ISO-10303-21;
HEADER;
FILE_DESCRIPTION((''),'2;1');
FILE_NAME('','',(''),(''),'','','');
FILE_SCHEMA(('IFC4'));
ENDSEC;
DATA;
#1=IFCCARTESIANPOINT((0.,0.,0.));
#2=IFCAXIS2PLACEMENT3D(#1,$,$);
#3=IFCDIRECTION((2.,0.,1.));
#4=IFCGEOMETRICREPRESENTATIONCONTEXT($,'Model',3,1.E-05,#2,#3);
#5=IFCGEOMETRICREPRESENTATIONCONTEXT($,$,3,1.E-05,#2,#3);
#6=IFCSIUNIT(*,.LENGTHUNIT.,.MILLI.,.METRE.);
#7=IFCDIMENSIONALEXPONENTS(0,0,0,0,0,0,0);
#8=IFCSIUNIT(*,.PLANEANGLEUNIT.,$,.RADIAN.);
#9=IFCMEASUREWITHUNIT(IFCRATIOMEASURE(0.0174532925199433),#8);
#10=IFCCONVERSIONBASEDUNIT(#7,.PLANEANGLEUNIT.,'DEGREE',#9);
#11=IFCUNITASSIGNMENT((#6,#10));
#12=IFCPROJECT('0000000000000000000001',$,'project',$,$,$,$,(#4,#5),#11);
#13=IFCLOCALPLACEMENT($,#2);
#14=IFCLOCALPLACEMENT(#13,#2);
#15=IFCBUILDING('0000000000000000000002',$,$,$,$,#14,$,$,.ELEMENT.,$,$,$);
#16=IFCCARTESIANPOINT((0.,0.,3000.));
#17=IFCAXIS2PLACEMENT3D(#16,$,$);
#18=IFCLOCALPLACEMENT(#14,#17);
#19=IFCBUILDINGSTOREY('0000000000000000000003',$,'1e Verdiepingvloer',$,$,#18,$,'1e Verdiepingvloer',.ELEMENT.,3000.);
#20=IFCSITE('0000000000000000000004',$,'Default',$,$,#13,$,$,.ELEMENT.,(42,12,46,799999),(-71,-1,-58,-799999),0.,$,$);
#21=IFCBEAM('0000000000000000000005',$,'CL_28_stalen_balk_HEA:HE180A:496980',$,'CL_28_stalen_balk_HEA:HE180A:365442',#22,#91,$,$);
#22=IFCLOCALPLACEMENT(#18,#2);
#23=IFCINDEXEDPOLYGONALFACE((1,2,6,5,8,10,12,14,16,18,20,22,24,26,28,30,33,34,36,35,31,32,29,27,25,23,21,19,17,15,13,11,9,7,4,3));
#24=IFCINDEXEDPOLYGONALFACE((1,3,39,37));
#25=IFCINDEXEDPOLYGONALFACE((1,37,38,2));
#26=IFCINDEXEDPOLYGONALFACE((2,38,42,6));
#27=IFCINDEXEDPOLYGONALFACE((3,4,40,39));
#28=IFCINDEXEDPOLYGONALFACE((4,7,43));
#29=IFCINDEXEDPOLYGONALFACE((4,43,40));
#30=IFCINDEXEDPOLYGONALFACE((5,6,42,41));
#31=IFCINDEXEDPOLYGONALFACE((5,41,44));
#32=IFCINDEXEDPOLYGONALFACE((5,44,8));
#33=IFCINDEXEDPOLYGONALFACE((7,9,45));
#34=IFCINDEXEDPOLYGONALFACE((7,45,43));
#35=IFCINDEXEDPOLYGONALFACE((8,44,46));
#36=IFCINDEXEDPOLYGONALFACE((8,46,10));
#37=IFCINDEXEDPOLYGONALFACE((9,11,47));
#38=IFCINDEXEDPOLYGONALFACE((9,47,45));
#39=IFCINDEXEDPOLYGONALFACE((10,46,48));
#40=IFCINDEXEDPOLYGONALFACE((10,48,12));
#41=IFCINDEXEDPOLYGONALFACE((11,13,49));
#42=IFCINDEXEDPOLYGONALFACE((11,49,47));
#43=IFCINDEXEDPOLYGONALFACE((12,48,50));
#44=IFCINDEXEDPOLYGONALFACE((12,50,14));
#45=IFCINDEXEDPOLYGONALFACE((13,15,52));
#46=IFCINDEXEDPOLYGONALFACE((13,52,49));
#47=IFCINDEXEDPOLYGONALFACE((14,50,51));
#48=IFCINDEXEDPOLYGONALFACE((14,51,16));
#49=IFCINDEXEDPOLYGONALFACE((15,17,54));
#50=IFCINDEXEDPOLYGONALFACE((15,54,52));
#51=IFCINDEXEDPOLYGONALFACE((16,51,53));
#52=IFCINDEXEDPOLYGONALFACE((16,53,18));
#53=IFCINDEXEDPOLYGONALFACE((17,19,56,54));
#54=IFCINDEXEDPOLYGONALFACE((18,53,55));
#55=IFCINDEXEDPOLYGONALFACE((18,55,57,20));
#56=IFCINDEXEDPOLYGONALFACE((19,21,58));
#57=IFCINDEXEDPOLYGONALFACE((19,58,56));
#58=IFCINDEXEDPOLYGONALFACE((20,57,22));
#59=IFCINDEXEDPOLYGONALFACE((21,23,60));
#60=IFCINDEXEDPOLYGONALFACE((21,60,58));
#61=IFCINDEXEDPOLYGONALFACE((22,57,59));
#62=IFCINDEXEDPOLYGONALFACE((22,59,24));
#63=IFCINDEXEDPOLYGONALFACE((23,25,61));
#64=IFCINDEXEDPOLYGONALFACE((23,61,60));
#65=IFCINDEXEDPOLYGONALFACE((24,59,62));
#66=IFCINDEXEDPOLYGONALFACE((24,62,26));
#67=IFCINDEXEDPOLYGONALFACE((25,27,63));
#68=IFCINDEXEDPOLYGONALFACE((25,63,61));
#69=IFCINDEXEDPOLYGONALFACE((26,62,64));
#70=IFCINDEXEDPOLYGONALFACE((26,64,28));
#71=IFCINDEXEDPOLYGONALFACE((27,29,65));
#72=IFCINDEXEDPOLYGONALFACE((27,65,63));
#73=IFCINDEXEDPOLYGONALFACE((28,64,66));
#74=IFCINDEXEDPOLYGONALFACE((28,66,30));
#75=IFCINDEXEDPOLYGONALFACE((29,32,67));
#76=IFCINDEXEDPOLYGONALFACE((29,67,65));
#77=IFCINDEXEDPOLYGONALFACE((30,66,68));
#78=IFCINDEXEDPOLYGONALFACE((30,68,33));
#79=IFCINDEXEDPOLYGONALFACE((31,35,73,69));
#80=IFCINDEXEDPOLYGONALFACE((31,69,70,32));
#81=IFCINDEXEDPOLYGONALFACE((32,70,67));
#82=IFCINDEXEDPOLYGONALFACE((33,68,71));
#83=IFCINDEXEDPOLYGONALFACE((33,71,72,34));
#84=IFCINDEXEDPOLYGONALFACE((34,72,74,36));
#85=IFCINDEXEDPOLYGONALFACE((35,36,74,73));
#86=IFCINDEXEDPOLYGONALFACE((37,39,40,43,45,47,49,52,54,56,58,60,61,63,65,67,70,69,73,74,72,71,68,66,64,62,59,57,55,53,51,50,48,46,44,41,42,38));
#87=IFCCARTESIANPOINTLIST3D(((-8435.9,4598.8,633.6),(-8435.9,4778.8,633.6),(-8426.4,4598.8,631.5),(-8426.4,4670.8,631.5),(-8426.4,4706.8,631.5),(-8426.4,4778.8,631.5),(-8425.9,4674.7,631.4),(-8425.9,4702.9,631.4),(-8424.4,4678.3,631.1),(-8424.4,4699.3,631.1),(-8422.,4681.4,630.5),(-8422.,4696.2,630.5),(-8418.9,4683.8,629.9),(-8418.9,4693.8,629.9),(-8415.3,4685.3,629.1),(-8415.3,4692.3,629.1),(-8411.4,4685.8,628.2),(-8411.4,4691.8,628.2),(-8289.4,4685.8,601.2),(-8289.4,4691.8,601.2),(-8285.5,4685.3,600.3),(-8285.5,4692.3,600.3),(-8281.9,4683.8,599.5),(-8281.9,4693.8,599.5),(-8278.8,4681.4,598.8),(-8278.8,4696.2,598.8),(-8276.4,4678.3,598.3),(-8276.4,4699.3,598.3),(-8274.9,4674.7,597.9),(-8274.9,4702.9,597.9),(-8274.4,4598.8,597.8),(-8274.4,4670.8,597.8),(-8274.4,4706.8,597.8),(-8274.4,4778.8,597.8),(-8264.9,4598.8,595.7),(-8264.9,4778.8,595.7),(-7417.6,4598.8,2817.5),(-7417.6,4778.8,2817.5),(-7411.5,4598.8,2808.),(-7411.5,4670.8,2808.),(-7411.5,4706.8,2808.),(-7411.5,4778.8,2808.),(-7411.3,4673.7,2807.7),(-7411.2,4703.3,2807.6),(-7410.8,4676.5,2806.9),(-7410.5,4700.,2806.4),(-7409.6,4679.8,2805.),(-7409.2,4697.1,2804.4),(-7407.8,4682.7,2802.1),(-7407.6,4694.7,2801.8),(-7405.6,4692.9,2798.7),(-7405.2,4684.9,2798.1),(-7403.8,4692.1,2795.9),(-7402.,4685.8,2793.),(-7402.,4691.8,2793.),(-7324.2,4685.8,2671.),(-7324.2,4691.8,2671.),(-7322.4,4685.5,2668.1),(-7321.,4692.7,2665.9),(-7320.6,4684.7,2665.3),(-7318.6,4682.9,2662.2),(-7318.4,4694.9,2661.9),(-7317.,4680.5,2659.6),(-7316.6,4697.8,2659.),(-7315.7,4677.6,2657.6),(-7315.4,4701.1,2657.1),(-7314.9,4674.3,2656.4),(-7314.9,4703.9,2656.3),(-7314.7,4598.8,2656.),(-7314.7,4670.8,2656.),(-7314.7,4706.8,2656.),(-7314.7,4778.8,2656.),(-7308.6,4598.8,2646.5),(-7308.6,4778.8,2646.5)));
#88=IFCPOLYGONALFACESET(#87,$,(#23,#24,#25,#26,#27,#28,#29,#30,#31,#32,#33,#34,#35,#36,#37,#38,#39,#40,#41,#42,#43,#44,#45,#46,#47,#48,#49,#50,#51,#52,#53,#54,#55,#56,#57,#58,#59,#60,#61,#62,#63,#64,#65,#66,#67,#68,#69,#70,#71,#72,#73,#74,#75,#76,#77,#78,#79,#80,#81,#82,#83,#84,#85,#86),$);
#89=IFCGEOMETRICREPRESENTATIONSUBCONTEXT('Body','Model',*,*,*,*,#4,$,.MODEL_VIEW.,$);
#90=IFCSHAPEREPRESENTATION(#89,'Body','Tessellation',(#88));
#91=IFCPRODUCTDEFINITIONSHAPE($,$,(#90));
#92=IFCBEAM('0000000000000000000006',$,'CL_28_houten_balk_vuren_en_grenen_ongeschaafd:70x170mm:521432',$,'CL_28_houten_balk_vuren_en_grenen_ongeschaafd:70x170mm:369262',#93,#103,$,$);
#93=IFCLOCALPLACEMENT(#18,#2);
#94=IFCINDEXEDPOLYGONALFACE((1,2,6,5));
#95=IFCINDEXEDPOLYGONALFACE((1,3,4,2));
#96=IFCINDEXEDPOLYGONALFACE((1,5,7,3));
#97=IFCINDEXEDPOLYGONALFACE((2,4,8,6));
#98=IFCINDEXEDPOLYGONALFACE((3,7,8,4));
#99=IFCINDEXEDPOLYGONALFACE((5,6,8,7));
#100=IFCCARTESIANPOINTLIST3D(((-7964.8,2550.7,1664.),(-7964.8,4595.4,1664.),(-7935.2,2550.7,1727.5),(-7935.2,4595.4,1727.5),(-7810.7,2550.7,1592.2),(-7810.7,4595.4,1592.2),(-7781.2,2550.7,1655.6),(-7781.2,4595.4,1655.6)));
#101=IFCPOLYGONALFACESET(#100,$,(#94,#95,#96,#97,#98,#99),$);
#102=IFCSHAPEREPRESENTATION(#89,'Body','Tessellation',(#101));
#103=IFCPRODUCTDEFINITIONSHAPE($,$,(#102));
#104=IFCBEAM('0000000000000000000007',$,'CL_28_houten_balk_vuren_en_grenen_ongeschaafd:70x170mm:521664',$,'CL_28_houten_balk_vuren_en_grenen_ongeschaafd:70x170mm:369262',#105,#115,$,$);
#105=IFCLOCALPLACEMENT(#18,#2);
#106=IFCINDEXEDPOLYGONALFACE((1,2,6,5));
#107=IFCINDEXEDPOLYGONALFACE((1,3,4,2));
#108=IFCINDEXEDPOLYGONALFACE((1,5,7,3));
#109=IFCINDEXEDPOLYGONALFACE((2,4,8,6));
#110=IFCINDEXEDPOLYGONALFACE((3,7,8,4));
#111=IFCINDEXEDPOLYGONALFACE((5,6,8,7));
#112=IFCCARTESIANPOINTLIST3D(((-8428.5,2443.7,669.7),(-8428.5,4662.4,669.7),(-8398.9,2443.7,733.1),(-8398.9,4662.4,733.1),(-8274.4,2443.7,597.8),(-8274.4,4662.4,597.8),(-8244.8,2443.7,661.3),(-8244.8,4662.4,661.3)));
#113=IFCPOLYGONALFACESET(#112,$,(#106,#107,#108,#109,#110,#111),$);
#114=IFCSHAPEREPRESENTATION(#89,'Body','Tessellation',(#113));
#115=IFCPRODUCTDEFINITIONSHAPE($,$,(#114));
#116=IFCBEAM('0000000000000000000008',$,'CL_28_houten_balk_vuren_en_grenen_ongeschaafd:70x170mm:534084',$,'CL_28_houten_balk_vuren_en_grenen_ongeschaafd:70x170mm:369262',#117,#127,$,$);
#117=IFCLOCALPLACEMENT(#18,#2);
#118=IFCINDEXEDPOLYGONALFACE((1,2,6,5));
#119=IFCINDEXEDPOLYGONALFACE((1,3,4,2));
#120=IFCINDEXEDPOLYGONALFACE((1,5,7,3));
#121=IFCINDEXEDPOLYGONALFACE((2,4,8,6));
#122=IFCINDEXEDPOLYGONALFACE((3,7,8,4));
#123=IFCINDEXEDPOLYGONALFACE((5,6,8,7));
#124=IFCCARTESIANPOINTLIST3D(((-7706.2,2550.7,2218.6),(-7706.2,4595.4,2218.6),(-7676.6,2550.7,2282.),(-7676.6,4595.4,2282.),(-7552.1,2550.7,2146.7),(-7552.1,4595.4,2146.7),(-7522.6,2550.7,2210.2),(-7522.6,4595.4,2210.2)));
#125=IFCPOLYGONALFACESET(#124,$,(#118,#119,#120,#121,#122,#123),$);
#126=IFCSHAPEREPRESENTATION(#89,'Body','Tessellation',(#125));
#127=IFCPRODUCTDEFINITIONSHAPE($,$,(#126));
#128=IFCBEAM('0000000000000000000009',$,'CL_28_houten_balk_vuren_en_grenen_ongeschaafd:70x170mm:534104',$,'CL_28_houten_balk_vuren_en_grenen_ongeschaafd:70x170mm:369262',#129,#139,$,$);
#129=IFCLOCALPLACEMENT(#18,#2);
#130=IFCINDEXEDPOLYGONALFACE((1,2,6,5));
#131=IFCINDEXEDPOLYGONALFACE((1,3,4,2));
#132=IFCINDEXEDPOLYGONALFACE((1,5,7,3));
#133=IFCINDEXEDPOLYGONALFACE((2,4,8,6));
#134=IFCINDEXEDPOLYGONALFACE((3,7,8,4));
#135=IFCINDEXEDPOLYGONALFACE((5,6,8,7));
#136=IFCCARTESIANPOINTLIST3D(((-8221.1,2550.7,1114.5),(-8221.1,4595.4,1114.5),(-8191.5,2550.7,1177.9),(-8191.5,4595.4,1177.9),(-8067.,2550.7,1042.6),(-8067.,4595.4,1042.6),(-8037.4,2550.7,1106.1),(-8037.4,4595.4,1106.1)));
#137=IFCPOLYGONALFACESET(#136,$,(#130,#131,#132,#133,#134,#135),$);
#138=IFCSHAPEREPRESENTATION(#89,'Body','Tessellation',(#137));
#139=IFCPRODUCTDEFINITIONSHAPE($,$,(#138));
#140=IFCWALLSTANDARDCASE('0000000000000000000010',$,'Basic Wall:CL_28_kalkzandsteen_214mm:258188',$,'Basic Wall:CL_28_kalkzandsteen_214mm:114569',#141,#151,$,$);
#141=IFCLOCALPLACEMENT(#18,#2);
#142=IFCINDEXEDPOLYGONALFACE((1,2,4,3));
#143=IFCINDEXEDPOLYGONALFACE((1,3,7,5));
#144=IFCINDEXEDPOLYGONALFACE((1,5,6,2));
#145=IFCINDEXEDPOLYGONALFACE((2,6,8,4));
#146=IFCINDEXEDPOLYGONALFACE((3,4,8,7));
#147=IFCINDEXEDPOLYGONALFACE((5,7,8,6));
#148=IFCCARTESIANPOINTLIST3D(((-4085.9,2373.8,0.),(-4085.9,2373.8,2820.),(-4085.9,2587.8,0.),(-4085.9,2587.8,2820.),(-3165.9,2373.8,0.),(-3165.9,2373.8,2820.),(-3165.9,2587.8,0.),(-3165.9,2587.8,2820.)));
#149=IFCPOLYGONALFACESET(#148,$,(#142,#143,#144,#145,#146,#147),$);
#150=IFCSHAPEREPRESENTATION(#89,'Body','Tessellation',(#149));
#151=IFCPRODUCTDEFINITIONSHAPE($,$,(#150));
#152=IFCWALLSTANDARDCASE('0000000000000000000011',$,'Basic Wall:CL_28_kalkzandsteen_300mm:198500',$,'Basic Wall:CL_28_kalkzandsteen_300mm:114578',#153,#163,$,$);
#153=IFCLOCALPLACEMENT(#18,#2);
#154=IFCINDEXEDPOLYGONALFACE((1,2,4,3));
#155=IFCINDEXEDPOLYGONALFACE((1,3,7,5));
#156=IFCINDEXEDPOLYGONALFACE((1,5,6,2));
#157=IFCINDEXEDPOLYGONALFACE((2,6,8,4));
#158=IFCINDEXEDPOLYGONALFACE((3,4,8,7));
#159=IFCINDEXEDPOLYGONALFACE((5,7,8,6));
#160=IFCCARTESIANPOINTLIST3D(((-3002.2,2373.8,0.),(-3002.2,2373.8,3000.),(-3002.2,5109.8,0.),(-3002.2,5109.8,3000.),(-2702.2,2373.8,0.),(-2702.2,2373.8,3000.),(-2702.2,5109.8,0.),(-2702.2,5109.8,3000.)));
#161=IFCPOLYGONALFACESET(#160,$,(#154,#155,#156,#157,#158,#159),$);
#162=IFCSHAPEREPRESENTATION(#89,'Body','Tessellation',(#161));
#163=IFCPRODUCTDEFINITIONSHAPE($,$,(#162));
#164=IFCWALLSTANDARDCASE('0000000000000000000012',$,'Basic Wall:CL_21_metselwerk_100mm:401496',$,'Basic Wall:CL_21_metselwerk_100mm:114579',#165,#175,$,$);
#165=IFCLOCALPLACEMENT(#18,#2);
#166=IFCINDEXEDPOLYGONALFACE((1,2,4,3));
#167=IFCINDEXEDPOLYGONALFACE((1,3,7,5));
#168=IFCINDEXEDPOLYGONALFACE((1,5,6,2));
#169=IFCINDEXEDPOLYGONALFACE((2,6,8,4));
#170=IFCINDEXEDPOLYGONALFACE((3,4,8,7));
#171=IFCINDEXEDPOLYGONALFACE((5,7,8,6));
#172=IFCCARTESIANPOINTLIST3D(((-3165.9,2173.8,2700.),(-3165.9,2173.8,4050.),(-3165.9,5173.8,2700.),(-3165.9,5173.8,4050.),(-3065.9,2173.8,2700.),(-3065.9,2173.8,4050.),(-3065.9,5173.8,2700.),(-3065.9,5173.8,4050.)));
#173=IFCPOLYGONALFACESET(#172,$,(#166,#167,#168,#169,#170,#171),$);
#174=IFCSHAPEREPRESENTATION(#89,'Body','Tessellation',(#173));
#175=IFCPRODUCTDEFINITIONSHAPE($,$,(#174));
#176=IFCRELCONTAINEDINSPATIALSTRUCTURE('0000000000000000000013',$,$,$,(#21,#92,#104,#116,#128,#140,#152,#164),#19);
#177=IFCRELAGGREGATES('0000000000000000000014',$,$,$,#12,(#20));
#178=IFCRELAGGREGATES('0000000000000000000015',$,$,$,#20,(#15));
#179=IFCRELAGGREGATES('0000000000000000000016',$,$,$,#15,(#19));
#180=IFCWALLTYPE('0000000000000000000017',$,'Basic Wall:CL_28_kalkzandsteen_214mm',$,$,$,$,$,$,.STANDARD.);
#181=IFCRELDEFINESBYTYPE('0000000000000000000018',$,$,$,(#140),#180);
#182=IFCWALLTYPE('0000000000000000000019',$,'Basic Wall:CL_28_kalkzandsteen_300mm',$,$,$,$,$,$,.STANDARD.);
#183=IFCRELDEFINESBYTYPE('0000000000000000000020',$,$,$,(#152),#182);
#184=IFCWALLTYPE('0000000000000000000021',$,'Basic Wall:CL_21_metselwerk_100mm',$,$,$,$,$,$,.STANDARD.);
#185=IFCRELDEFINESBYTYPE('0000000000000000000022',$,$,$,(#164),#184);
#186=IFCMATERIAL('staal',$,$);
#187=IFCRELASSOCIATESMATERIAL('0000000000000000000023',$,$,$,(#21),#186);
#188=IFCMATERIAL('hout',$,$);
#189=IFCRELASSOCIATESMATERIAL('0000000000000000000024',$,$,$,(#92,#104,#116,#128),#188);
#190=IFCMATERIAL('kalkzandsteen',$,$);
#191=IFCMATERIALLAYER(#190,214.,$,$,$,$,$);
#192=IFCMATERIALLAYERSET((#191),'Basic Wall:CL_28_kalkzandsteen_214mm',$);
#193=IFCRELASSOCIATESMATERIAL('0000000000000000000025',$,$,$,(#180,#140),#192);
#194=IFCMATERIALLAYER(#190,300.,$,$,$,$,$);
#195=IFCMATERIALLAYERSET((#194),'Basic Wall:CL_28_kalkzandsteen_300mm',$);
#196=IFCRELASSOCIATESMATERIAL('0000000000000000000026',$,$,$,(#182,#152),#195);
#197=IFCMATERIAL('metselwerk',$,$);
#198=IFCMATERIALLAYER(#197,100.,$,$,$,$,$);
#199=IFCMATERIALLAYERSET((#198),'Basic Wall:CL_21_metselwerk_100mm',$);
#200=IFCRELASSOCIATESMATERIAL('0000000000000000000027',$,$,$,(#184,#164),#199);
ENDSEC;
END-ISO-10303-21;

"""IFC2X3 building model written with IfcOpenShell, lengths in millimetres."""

from ifc_helpers import new_model, entity, si_unit, converted_unit, direction, frame, frame_2d, origin, origin_2d_with_axis, place, context, subcontext, project, spatial, polyline, circle_curve, parameter, trimmed, segment, composite_curve, rectangle, outline, extrude, clip, halfspace, material, layer, layer_set, layer_usage, type_object, element, save


model = new_model("IFC2X3")

# Units and contexts
model_context = context("Model", 3, precision=1e-05, world=origin(), true_north=direction((2.0, 0.0, 1.0)))
context_of_model = context(None, 3, precision=1e-05, world=origin(), true_north=direction((2.0, 0.0, 1.0)))
body_context = subcontext(model_context, "Body", "Model", "MODEL_VIEW")
ifc_project = project(units=[si_unit("LENGTHUNIT", "METRE", prefix="MILLI"), converted_unit("PLANEANGLEUNIT", "DEGREE", entity("IfcRatioMeasure", 0.0174532925199433), si_unit("PLANEANGLEUNIT", "RADIAN"), dimensions=[0, 0, 0, 0, 0, 0, 0])], contexts=[model_context, context_of_model])

# Site, building, storey
site_placement = place(None, origin())
site = spatial("IfcSite", under=ifc_project, at=site_placement, Name="Default", CompositionType="ELEMENT", RefLatitude=(42, 12, 46, 799999), RefLongitude=(-71, -1, -58, -799999), RefElevation=0.0)
building_placement = place(site_placement, origin())
building = spatial("IfcBuilding", under=site, at=building_placement, CompositionType="ELEMENT")
storey_placement = place(building_placement, frame((0.0, 0.0, 3000.0)))
storey = spatial("IfcBuildingStorey", under=building, at=storey_placement, Name="1e Verdiepingvloer", LongName="1e Verdiepingvloer", CompositionType="ELEMENT", Elevation=3000.0)

# Beams
ifc_material_1 = material(Name="staal")
ifc_material_2 = material(Name="hout")
beam_1_placement = place(storey_placement, frame((-8498.2, 4688.8, 500.0), z_axis=(0.906308, 0.0, -0.422618), x_axis=(0.422618, 0.0, 0.906308)))
element("IfcBeam", 1, at=beam_1_placement, inside=storey, material=ifc_material_1, Name="CL_28_stalen_balk_HEA:HE180A:496980", ObjectType="CL_28_stalen_balk_HEA:HE180A:365442", context=body_context, shape_type="Clipping", body=[
    clip(clip(extrude(outline(composite_curve([segment(polyline([(76.0, -90.0), (85.5, -90.0)]), True, "CONTINUOUS"), segment(polyline([(85.5, -90.0), (85.5, 90.0)]), True, "CONTINUOUS"), segment(polyline([(85.5, 90.0), (76.0, 90.0)]), True, "CONTINUOUS"), segment(polyline([(76.0, 90.0), (76.0, 18.0)]), True, "CONTINUOUS"), segment(trimmed(circle_curve(frame_2d((61.0, 18.0), x_axis=(1.0, 0.0)), 15.0), [parameter(270.0)], [parameter(0.0)], True, "PARAMETER"), False, "CONTINUOUS"), segment(polyline([(61.0, 3.0), (-61.0, 3.0)]), True, "CONTINUOUS"), segment(trimmed(circle_curve(frame_2d((-61.0, 18.0), x_axis=(0.0, -1.0)), 15.0), [parameter(270.0)], [parameter(0.0)], True, "PARAMETER"), False, "CONTINUOUS"), segment(polyline([(-76.0, 18.0), (-76.0, 90.0)]), True, "CONTINUOUS"), segment(polyline([(-76.0, 90.0), (-85.5, 90.0)]), True, "CONTINUOUS"), segment(polyline([(-85.5, 90.0), (-85.5, -90.0)]), True, "CONTINUOUS"), segment(polyline([(-85.5, -90.0), (-76.0, -90.0)]), True, "CONTINUOUS"), segment(polyline([(-76.0, -90.0), (-76.0, -18.0)]), True, "CONTINUOUS"), segment(trimmed(circle_curve(frame_2d((-61.0, -18.0), x_axis=(-1.0, 0.0)), 15.0), [parameter(270.0)], [parameter(0.0)], True, "PARAMETER"), False, "CONTINUOUS"), segment(polyline([(-61.0, -3.0), (61.0, -3.0)]), True, "CONTINUOUS"), segment(trimmed(circle_curve(frame_2d((61.0, -18.0), x_axis=(0.0, 1.0)), 15.0), [parameter(270.0)], [parameter(0.0)], True, "PARAMETER"), False, "CONTINUOUS"), segment(polyline([(76.0, -18.0), (76.0, -90.0)]), True, "CONTINUOUS")], self_intersect=False)), frame((147.4, 0.0, 85.5), z_axis=(1.0, 0.0, 0.0), x_axis=(0.0, 0.0, -1.0)), (0.0, 0.0, 1.0), 2409.6), halfspace(frame((2453.6, 251.2, 162.5), z_axis=(0.843391, 0.0, 0.5373), x_axis=(-0.5373, 0.0, 0.843391)), False)), halfspace(frame((147.4, 251.2, 0.0), z_axis=(-0.976296, 0.0, 0.21644), x_axis=(0.21644, 0.0, 0.976296)), False)),
])
beam_2_placement = place(storey_placement, frame((-7950.0, 2480.8, 1695.8), z_axis=(0.0, 0.0, 1.0), x_axis=(0.0, 1.0, 0.0)))
element("IfcBeam", 2, at=beam_2_placement, inside=storey, material=ifc_material_2, Name="CL_28_houten_balk_vuren_en_grenen_ongeschaafd:70x170mm:521432", ObjectType="CL_28_houten_balk_vuren_en_grenen_ongeschaafd:70x170mm:369262", context=body_context, shape_type="SweptSolid", body=[
    extrude(rectangle(XDim=70.0, YDim=170.0, at=origin_2d_with_axis()), frame((69.9, -77.0, -35.9), z_axis=(1.0, 0.0, 0.0), x_axis=(0.0, -0.422618, 0.906308)), (0.0, 0.0, 1.0), 2044.8),
])
beam_3_placement = place(storey_placement, frame((-8413.7, 2480.8, 701.4), z_axis=(0.0, 0.0, 1.0), x_axis=(0.0, 1.0, 0.0)))
element("IfcBeam", 3, at=beam_3_placement, inside=storey, material=ifc_material_2, Name="CL_28_houten_balk_vuren_en_grenen_ongeschaafd:70x170mm:521664", ObjectType="CL_28_houten_balk_vuren_en_grenen_ongeschaafd:70x170mm:369262", context=body_context, shape_type="SweptSolid", body=[
    extrude(rectangle(XDim=70.0, YDim=170.0, at=origin_2d_with_axis()), frame((-37.1, -77.0, -35.9), z_axis=(1.0, 0.0, 0.0), x_axis=(0.0, -0.422618, 0.906308)), (0.0, 0.0, 1.0), 2218.8),
])
beam_4_placement = place(storey_placement, frame((-7691.4, 2480.8, 2250.3), z_axis=(0.0, 0.0, 1.0), x_axis=(0.0, 1.0, 0.0)))
element("IfcBeam", 4, at=beam_4_placement, inside=storey, material=ifc_material_2, Name="CL_28_houten_balk_vuren_en_grenen_ongeschaafd:70x170mm:534084", ObjectType="CL_28_houten_balk_vuren_en_grenen_ongeschaafd:70x170mm:369262", context=body_context, shape_type="SweptSolid", body=[
    extrude(rectangle(XDim=70.0, YDim=170.0, at=frame_2d((0.0, 0.0), x_axis=(1.0, 0.0))), frame((69.9, -77.0, -35.9), z_axis=(1.0, 0.0, 0.0), x_axis=(0.0, -0.422618, 0.906308)), (0.0, 0.0, 1.0), 2044.8),
])
beam_5_placement = place(storey_placement, frame((-8206.3, 2480.8, 1146.2), z_axis=(0.0, 0.0, 1.0), x_axis=(0.0, 1.0, 0.0)))
element("IfcBeam", 5, at=beam_5_placement, inside=storey, material=ifc_material_2, Name="CL_28_houten_balk_vuren_en_grenen_ongeschaafd:70x170mm:534104", ObjectType="CL_28_houten_balk_vuren_en_grenen_ongeschaafd:70x170mm:369262", context=body_context, shape_type="SweptSolid", body=[
    extrude(rectangle(XDim=70.0, YDim=170.0, at=frame_2d((0.0, 0.0), x_axis=(1.0, 0.0))), frame((69.9, -77.0, -35.9), z_axis=(1.0, 0.0, 0.0), x_axis=(0.0, -0.422618, 0.906308)), (0.0, 0.0, 1.0), 2044.8),
])

# Walls
ifc_material_3 = material(Name="kalkzandsteen")
ifc_layer_1 = layer(ifc_material_3, 214.0)
ifc_layer_set_1 = layer_set([ifc_layer_1], Name="Basic Wall:CL_28_kalkzandsteen_214mm")
ifc_layer_usage_1 = layer_usage(ifc_layer_set_1, "AXIS2", "NEGATIVE", 107.0)
wall_type_1 = type_object("IfcWallType", Name="Basic Wall:CL_28_kalkzandsteen_214mm", PredefinedType="STANDARD", material=ifc_layer_set_1)
wall_1_placement = place(storey_placement, frame((-4085.9, 2480.8, 0.0)))
element("IfcWallStandardCase", 6, at=wall_1_placement, inside=storey, type_object=wall_type_1, material=ifc_layer_usage_1, Name="Basic Wall:CL_28_kalkzandsteen_214mm:258188", ObjectType="Basic Wall:CL_28_kalkzandsteen_214mm:114569", context=body_context, shape_type="SweptSolid", body=[
    extrude(rectangle(XDim=920.0, YDim=214.0, at=frame_2d((460.0, 0.0), x_axis=(-1.0, 0.0))), origin(), (0.0, 0.0, 1.0), 2820.0),
])
ifc_layer_2 = layer(ifc_material_3, 300.0)
ifc_layer_set_2 = layer_set([ifc_layer_2], Name="Basic Wall:CL_28_kalkzandsteen_300mm")
ifc_layer_usage_2 = layer_usage(ifc_layer_set_2, "AXIS2", "NEGATIVE", 150.0)
wall_type_2 = type_object("IfcWallType", Name="Basic Wall:CL_28_kalkzandsteen_300mm", PredefinedType="STANDARD", material=ifc_layer_set_2)
wall_2_placement = place(storey_placement, frame((-2852.2, 5109.8, 0.0), z_axis=(0.0, 0.0, 1.0), x_axis=(0.0, -1.0, 0.0)))
element("IfcWallStandardCase", 7, at=wall_2_placement, inside=storey, type_object=wall_type_2, material=ifc_layer_usage_2, Name="Basic Wall:CL_28_kalkzandsteen_300mm:198500", ObjectType="Basic Wall:CL_28_kalkzandsteen_300mm:114578", context=body_context, shape_type="SweptSolid", body=[
    extrude(rectangle(XDim=2736.0, YDim=300.0, at=frame_2d((1368.0, 0.0), x_axis=(-1.0, 0.0))), origin(), (0.0, 0.0, 1.0), 3000.0),
])
ifc_material_4 = material(Name="metselwerk")
ifc_layer_3 = layer(ifc_material_4, 100.0)
ifc_layer_set_3 = layer_set([ifc_layer_3], Name="Basic Wall:CL_21_metselwerk_100mm")
ifc_layer_usage_3 = layer_usage(ifc_layer_set_3, "AXIS2", "NEGATIVE", 50.0)
wall_type_3 = type_object("IfcWallType", Name="Basic Wall:CL_21_metselwerk_100mm", PredefinedType="STANDARD", material=ifc_layer_set_3)
wall_3_placement = place(storey_placement, frame((-3115.9, 5173.8, 2700.0), z_axis=(0.0, 0.0, 1.0), x_axis=(0.0, -1.0, 0.0)))
element("IfcWallStandardCase", 8, at=wall_3_placement, inside=storey, type_object=wall_type_3, material=ifc_layer_usage_3, Name="Basic Wall:CL_21_metselwerk_100mm:401496", ObjectType="Basic Wall:CL_21_metselwerk_100mm:114579", context=body_context, shape_type="SweptSolid", body=[
    extrude(rectangle(XDim=3000.0, YDim=100.0, at=frame_2d((1500.0, 0.0), x_axis=(-1.0, 0.0))), origin(), (0.0, 0.0, 1.0), 1350.0),
])

save(model, "model.ifc")
